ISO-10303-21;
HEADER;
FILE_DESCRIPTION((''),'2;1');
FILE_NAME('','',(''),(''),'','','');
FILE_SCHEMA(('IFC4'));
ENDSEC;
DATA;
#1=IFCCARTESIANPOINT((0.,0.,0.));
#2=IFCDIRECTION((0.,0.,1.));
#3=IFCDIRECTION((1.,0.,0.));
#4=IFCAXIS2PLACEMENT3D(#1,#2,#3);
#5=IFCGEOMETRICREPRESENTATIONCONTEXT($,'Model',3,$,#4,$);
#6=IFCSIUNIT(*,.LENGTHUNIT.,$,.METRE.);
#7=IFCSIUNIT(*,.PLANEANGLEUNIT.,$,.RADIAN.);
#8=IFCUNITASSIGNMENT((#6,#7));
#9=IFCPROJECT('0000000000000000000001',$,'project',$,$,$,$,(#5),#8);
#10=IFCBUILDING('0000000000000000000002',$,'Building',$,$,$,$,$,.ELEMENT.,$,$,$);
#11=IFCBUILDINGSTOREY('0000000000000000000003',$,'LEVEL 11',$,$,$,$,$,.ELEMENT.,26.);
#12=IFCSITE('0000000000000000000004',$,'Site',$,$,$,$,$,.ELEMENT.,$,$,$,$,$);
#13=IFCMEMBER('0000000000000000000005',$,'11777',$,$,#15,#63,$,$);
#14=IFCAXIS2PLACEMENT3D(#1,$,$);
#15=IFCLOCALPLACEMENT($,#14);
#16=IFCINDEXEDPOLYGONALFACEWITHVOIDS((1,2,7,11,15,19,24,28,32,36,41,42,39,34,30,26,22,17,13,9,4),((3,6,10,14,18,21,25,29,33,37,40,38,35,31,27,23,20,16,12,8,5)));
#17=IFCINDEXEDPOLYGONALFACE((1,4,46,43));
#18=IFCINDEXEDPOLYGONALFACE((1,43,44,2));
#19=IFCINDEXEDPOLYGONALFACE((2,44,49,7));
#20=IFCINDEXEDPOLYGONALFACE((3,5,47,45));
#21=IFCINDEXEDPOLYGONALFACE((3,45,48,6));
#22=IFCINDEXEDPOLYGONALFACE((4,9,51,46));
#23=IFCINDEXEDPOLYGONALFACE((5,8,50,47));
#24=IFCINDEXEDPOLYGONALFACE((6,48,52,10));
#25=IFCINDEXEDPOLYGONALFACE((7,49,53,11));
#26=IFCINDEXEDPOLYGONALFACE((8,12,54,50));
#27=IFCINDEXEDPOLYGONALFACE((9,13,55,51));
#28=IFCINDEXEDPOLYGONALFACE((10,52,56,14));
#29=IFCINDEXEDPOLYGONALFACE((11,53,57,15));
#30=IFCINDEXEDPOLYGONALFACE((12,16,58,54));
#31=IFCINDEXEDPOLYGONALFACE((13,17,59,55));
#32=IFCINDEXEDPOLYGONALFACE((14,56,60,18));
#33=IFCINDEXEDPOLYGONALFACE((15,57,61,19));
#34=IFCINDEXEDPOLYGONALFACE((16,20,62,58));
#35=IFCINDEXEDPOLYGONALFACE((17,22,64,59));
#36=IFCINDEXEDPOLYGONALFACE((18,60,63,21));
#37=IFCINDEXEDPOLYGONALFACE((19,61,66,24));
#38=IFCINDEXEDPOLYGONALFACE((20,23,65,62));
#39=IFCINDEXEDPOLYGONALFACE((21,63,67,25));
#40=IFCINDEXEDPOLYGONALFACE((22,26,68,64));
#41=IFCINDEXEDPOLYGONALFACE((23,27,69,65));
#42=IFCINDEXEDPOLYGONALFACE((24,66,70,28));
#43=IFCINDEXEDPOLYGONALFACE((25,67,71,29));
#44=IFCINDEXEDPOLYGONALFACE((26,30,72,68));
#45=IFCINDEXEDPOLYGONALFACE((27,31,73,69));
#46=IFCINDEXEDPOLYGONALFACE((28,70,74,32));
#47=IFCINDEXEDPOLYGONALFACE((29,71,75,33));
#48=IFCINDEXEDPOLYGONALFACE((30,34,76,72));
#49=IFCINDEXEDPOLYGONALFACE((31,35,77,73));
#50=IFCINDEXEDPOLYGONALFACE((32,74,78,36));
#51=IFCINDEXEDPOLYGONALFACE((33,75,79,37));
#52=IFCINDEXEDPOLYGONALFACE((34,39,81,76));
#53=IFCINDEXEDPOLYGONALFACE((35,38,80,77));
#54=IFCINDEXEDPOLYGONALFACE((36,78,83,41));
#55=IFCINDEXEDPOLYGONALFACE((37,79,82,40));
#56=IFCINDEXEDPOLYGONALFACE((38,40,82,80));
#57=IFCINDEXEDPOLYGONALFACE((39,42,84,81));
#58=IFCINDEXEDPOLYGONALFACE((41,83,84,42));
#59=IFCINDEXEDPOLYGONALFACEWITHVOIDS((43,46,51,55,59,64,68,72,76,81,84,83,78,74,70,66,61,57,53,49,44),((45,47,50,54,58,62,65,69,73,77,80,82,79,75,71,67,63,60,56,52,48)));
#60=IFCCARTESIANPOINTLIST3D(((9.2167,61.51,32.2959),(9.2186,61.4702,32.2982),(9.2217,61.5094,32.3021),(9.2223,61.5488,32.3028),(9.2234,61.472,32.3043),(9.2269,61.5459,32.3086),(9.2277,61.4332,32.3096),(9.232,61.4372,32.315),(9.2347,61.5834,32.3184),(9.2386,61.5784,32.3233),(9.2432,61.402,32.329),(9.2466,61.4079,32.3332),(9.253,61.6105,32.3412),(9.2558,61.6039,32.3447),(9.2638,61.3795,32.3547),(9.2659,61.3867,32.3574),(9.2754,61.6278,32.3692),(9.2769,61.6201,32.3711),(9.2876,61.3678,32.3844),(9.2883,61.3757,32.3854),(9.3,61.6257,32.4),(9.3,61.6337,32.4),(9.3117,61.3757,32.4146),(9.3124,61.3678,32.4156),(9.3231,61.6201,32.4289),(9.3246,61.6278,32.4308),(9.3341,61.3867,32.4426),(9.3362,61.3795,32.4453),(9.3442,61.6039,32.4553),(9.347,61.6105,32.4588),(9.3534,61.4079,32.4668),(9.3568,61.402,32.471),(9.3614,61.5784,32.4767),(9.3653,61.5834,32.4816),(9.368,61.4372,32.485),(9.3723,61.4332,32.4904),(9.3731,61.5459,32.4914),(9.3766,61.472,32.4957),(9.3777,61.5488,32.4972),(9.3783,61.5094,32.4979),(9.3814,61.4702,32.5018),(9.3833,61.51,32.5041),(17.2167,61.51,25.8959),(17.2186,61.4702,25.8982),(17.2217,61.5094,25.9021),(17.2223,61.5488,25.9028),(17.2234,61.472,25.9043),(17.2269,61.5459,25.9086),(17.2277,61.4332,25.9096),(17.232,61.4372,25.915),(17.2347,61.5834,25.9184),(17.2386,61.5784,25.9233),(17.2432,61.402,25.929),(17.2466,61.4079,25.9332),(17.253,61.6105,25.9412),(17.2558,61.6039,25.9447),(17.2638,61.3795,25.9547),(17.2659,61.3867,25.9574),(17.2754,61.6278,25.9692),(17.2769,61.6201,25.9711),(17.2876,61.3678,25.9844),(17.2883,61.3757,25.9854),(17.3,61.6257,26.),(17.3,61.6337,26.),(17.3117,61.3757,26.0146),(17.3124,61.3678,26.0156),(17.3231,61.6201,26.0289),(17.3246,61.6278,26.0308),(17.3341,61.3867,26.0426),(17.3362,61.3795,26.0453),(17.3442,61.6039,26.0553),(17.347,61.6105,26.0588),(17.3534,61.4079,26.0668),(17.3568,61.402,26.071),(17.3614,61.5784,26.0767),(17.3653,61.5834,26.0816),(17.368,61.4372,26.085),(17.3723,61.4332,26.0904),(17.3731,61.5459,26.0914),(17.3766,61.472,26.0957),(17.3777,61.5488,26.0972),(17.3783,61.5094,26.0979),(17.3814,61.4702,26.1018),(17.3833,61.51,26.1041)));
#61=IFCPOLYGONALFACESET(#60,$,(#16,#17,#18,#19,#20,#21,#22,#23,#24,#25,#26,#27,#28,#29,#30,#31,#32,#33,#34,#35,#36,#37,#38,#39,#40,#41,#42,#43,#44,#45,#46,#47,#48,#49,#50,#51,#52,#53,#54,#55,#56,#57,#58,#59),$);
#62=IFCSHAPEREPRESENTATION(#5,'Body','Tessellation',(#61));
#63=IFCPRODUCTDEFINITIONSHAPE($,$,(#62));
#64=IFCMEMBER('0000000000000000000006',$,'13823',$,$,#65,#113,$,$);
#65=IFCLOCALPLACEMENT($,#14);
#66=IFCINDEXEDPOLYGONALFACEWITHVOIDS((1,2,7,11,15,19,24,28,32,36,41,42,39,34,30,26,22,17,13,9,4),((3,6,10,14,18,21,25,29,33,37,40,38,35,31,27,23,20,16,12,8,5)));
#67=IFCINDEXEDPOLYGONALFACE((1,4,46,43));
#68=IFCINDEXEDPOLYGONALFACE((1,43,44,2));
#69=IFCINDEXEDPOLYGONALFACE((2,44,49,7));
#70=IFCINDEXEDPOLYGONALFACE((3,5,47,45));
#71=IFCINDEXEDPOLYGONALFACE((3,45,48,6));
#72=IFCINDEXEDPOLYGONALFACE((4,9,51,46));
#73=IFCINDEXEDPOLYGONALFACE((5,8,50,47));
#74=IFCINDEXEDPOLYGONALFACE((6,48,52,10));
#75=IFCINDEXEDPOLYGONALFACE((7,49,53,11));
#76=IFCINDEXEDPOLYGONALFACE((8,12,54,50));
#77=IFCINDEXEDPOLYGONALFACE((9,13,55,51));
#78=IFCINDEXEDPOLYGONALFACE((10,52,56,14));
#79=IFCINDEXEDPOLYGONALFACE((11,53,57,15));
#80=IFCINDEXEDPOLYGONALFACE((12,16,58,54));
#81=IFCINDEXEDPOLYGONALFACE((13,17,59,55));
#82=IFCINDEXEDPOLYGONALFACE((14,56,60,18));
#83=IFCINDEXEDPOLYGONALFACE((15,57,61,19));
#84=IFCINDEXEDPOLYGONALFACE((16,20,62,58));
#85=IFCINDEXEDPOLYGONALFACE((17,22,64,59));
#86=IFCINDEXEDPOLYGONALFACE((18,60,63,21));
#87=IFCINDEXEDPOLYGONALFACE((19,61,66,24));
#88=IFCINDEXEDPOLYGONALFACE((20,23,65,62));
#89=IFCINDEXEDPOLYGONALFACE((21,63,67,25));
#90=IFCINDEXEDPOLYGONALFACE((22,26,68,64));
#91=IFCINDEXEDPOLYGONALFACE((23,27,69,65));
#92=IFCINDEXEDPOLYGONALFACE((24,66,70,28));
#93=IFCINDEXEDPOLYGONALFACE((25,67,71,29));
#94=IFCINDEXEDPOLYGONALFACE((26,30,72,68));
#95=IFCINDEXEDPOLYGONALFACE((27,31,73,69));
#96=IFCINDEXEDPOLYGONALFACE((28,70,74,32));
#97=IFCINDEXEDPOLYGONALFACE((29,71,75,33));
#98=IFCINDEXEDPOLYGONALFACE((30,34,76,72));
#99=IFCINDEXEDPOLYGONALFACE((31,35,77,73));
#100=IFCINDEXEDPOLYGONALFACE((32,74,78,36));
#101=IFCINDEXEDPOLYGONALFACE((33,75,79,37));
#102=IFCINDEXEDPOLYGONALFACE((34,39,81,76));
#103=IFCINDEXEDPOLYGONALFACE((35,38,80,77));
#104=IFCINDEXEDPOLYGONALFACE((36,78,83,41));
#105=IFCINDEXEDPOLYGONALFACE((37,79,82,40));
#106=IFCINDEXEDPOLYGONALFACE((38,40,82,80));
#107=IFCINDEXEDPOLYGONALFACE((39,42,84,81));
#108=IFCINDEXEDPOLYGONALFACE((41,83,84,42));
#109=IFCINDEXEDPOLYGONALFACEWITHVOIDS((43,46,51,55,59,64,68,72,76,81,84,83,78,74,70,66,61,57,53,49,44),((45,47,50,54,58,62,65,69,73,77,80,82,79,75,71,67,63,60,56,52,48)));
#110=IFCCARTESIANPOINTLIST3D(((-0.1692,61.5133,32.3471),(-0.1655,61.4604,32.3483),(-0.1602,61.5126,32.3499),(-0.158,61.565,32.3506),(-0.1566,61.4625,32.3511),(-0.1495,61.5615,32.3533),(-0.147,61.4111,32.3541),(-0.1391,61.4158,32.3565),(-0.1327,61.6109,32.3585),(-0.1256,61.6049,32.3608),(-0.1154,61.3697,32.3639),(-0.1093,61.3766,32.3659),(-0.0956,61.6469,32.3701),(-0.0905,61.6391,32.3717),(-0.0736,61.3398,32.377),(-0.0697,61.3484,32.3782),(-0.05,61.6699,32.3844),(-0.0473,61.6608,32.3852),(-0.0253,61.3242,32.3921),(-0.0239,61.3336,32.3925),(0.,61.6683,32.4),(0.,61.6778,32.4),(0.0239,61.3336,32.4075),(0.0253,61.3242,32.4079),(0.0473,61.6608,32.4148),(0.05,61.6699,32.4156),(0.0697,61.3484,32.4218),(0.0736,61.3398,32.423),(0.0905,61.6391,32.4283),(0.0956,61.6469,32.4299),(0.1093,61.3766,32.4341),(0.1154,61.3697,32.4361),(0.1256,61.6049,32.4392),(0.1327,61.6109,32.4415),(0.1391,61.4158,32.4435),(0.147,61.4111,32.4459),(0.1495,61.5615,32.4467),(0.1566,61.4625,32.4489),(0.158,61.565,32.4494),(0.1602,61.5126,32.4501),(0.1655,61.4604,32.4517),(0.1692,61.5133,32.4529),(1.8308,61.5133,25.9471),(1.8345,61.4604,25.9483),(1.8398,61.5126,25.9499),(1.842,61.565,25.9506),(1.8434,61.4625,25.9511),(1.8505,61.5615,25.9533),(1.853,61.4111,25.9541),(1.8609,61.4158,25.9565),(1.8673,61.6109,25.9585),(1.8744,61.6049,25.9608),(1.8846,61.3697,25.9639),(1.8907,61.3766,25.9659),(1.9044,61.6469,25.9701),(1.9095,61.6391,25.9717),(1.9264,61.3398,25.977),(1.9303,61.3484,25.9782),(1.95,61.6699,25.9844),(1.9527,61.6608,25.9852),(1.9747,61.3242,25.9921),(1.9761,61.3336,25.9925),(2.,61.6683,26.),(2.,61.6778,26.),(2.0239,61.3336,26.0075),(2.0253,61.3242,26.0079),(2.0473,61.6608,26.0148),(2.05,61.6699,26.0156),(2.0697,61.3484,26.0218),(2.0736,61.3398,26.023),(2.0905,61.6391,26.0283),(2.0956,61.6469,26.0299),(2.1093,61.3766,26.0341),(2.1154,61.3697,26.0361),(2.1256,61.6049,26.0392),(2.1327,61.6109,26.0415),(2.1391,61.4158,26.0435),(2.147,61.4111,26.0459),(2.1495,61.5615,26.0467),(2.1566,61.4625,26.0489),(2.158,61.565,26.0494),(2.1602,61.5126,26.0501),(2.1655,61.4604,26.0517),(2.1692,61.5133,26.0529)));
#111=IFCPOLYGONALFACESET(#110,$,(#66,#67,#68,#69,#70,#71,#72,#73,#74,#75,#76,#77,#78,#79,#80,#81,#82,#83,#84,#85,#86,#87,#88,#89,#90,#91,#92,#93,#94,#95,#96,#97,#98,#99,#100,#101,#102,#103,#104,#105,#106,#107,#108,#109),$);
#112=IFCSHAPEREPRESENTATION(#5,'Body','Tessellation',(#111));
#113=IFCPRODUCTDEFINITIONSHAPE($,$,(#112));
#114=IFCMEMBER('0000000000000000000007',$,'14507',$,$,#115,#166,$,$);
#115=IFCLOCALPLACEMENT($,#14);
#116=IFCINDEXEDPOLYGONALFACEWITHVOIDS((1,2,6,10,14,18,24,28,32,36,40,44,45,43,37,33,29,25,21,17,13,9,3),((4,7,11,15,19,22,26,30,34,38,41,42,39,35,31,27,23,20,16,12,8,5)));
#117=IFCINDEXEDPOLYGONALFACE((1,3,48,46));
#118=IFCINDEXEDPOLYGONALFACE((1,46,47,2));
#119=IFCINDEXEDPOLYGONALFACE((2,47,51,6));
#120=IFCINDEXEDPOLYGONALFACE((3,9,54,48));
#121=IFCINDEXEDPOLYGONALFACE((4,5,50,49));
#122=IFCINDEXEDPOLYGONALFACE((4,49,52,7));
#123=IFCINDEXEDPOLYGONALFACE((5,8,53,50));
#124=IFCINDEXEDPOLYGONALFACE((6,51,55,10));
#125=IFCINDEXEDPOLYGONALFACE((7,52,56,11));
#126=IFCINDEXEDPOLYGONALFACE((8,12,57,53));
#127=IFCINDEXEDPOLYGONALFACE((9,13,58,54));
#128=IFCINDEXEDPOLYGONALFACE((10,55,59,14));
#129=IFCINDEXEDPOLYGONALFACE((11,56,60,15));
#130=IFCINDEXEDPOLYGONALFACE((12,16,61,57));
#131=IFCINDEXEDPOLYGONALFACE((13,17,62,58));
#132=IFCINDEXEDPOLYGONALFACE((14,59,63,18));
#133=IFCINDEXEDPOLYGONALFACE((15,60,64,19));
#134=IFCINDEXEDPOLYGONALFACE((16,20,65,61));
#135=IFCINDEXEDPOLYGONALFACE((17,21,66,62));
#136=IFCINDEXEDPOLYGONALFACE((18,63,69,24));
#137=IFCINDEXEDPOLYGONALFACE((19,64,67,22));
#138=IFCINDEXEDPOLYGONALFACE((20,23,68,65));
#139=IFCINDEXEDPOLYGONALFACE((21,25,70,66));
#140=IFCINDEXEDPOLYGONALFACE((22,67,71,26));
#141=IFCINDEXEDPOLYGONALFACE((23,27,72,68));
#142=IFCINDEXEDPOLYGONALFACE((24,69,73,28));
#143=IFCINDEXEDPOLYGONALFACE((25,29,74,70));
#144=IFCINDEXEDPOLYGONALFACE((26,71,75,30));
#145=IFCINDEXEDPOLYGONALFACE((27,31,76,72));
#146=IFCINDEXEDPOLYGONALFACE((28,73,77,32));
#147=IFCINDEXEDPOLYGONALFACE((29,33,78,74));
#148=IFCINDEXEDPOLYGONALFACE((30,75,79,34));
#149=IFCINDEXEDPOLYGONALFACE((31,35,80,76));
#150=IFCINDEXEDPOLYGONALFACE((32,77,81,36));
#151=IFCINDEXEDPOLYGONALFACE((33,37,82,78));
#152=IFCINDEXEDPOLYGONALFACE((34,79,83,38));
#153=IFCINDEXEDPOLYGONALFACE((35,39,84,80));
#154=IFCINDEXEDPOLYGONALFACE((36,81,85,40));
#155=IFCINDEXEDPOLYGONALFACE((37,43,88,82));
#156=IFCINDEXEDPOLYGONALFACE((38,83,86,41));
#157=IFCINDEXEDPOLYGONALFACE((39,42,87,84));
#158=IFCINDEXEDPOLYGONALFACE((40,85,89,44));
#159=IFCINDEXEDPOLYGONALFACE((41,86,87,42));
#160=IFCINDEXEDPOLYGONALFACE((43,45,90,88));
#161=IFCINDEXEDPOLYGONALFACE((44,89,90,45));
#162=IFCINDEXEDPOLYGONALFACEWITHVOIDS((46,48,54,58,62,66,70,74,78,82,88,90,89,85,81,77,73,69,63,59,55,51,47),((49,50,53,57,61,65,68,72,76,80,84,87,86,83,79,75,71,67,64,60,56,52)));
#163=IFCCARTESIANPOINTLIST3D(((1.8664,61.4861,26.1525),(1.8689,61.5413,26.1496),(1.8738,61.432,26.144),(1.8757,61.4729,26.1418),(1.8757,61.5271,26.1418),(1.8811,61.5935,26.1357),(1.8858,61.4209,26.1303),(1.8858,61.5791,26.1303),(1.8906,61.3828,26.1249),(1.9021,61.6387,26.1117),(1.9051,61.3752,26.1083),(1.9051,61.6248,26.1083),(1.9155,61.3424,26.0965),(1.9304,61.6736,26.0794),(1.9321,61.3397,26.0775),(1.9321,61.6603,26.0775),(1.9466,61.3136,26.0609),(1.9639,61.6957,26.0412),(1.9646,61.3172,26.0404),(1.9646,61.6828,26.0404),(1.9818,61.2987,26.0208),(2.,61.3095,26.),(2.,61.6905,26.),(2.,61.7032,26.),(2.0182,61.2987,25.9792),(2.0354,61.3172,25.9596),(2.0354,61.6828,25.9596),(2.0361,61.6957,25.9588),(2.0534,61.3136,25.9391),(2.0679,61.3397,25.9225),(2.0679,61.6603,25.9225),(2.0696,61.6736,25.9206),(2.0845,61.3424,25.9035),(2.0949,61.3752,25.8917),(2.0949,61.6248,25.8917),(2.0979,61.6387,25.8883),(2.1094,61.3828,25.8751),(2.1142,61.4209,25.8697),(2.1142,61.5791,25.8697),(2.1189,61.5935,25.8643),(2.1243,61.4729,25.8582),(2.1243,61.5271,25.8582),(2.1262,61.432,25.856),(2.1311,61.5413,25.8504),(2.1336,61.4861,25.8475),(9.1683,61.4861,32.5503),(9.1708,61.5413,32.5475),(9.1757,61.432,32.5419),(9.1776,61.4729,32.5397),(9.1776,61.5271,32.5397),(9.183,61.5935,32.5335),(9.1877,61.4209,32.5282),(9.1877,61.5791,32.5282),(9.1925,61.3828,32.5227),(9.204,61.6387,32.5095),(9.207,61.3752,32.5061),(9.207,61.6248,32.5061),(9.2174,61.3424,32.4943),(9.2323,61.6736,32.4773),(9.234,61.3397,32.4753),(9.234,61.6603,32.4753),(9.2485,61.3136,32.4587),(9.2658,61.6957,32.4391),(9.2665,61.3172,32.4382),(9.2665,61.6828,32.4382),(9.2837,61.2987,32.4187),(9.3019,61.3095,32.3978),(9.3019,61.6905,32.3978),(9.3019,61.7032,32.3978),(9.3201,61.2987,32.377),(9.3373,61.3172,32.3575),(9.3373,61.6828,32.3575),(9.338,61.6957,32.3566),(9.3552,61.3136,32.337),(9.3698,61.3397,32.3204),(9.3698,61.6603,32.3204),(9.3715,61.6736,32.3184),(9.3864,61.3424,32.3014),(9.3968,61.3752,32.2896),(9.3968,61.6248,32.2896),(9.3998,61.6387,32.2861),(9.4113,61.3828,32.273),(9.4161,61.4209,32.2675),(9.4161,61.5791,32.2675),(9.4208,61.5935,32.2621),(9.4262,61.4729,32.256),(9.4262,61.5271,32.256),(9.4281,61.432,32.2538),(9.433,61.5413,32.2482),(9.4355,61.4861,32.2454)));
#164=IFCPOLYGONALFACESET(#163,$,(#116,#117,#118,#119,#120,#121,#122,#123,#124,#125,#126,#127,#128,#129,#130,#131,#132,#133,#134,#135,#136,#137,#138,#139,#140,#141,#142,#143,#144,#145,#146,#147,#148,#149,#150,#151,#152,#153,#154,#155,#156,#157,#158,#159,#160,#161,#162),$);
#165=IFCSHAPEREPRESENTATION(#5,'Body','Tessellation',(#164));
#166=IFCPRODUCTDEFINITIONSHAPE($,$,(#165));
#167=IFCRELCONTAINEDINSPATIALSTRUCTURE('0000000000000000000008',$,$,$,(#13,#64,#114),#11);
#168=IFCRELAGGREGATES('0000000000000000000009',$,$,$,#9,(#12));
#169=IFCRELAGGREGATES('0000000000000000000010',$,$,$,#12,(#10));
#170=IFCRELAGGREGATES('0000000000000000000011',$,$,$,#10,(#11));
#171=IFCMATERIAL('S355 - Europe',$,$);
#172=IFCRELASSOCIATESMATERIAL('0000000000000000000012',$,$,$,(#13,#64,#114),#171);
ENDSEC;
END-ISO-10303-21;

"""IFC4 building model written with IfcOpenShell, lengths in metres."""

from ifc_helpers import new_model, si_unit, frame, origin_with_axes, origin_2d_with_axis, place, context, project, spatial, hollow_circle, extrude, material, material_profile, profile_set, profile_usage, element, save


model = new_model("IFC4")

# Units and contexts
model_context = context("Model", 3, world=origin_with_axes())
ifc_project = project(units=[si_unit("LENGTHUNIT", "METRE"), si_unit("PLANEANGLEUNIT", "RADIAN")], contexts=[model_context])

# Site, building, storey
site = spatial("IfcSite", under=ifc_project, Name="Site", CompositionType="ELEMENT")
building = spatial("IfcBuilding", under=site, Name="Building", CompositionType="ELEMENT")
storey = spatial("IfcBuildingStorey", under=building, Name="LEVEL 11", CompositionType="ELEMENT", Elevation=26.0)

# Shared definitions
ifc_material = material(Name="S355 - Europe")

# Members
ifc_material_profile_1 = material_profile(ifc_material, hollow_circle(Radius=0.1337, WallThickness=0.008, at=origin_2d_with_axis()))
ifc_profile_set_1 = profile_set([ifc_material_profile_1])
ifc_profile_usage_1 = profile_usage(ifc_profile_set_1, cardinal=10)
member_1_placement = place(None, frame((9.3, 61.5, 32.4), z_axis=(0.780869, 0.0, -0.624695), x_axis=(0.0, 1.0, 0.0)))
element("IfcMember", 1, at=member_1_placement, inside=storey, material=ifc_profile_usage_1, Name="11777", context=model_context, shape_type="SweptSolid", body=[
    extrude(hollow_circle(Radius=0.1337, WallThickness=0.008, at=origin_2d_with_axis()), origin_with_axes(), (0.0, 0.0, 1.0), 10.245),
])
ifc_material_profile_2 = material_profile(ifc_material, hollow_circle(Radius=0.1778, WallThickness=0.0095, at=origin_2d_with_axis()))
ifc_profile_set_2 = profile_set([ifc_material_profile_2])
ifc_profile_usage_2 = profile_usage(ifc_profile_set_2, cardinal=10)
member_2_placement = place(None, frame((0.0, 61.5, 32.4), z_axis=(0.298275, 0.0, -0.95448), x_axis=(0.0, 1.0, 0.0)))
element("IfcMember", 2, at=member_2_placement, inside=storey, material=ifc_profile_usage_2, Name="13823", context=model_context, shape_type="SweptSolid", body=[
    extrude(hollow_circle(Radius=0.1778, WallThickness=0.0095, at=origin_2d_with_axis()), origin_with_axes(), (0.0, 0.0, 1.0), 6.7052),
])
ifc_material_profile_3 = material_profile(ifc_material, hollow_circle(Radius=0.2032, WallThickness=0.0127, at=origin_2d_with_axis()))
ifc_profile_set_3 = profile_set([ifc_material_profile_3])
ifc_profile_usage_3 = profile_usage(ifc_profile_set_3, cardinal=10)
member_3_placement = place(None, frame((2.0, 61.5, 26.0), z_axis=(0.752133, 0.0, 0.659012), x_axis=(0.0, 1.0, 0.0)))
element("IfcMember", 3, at=member_3_placement, inside=storey, material=ifc_profile_usage_3, Name="14507", context=model_context, shape_type="SweptSolid", body=[
    extrude(hollow_circle(Radius=0.2032, WallThickness=0.0127, at=origin_2d_with_axis()), origin_with_axes(), (0.0, 0.0, 1.0), 9.7082),
])

save(model, "model.ifc")
